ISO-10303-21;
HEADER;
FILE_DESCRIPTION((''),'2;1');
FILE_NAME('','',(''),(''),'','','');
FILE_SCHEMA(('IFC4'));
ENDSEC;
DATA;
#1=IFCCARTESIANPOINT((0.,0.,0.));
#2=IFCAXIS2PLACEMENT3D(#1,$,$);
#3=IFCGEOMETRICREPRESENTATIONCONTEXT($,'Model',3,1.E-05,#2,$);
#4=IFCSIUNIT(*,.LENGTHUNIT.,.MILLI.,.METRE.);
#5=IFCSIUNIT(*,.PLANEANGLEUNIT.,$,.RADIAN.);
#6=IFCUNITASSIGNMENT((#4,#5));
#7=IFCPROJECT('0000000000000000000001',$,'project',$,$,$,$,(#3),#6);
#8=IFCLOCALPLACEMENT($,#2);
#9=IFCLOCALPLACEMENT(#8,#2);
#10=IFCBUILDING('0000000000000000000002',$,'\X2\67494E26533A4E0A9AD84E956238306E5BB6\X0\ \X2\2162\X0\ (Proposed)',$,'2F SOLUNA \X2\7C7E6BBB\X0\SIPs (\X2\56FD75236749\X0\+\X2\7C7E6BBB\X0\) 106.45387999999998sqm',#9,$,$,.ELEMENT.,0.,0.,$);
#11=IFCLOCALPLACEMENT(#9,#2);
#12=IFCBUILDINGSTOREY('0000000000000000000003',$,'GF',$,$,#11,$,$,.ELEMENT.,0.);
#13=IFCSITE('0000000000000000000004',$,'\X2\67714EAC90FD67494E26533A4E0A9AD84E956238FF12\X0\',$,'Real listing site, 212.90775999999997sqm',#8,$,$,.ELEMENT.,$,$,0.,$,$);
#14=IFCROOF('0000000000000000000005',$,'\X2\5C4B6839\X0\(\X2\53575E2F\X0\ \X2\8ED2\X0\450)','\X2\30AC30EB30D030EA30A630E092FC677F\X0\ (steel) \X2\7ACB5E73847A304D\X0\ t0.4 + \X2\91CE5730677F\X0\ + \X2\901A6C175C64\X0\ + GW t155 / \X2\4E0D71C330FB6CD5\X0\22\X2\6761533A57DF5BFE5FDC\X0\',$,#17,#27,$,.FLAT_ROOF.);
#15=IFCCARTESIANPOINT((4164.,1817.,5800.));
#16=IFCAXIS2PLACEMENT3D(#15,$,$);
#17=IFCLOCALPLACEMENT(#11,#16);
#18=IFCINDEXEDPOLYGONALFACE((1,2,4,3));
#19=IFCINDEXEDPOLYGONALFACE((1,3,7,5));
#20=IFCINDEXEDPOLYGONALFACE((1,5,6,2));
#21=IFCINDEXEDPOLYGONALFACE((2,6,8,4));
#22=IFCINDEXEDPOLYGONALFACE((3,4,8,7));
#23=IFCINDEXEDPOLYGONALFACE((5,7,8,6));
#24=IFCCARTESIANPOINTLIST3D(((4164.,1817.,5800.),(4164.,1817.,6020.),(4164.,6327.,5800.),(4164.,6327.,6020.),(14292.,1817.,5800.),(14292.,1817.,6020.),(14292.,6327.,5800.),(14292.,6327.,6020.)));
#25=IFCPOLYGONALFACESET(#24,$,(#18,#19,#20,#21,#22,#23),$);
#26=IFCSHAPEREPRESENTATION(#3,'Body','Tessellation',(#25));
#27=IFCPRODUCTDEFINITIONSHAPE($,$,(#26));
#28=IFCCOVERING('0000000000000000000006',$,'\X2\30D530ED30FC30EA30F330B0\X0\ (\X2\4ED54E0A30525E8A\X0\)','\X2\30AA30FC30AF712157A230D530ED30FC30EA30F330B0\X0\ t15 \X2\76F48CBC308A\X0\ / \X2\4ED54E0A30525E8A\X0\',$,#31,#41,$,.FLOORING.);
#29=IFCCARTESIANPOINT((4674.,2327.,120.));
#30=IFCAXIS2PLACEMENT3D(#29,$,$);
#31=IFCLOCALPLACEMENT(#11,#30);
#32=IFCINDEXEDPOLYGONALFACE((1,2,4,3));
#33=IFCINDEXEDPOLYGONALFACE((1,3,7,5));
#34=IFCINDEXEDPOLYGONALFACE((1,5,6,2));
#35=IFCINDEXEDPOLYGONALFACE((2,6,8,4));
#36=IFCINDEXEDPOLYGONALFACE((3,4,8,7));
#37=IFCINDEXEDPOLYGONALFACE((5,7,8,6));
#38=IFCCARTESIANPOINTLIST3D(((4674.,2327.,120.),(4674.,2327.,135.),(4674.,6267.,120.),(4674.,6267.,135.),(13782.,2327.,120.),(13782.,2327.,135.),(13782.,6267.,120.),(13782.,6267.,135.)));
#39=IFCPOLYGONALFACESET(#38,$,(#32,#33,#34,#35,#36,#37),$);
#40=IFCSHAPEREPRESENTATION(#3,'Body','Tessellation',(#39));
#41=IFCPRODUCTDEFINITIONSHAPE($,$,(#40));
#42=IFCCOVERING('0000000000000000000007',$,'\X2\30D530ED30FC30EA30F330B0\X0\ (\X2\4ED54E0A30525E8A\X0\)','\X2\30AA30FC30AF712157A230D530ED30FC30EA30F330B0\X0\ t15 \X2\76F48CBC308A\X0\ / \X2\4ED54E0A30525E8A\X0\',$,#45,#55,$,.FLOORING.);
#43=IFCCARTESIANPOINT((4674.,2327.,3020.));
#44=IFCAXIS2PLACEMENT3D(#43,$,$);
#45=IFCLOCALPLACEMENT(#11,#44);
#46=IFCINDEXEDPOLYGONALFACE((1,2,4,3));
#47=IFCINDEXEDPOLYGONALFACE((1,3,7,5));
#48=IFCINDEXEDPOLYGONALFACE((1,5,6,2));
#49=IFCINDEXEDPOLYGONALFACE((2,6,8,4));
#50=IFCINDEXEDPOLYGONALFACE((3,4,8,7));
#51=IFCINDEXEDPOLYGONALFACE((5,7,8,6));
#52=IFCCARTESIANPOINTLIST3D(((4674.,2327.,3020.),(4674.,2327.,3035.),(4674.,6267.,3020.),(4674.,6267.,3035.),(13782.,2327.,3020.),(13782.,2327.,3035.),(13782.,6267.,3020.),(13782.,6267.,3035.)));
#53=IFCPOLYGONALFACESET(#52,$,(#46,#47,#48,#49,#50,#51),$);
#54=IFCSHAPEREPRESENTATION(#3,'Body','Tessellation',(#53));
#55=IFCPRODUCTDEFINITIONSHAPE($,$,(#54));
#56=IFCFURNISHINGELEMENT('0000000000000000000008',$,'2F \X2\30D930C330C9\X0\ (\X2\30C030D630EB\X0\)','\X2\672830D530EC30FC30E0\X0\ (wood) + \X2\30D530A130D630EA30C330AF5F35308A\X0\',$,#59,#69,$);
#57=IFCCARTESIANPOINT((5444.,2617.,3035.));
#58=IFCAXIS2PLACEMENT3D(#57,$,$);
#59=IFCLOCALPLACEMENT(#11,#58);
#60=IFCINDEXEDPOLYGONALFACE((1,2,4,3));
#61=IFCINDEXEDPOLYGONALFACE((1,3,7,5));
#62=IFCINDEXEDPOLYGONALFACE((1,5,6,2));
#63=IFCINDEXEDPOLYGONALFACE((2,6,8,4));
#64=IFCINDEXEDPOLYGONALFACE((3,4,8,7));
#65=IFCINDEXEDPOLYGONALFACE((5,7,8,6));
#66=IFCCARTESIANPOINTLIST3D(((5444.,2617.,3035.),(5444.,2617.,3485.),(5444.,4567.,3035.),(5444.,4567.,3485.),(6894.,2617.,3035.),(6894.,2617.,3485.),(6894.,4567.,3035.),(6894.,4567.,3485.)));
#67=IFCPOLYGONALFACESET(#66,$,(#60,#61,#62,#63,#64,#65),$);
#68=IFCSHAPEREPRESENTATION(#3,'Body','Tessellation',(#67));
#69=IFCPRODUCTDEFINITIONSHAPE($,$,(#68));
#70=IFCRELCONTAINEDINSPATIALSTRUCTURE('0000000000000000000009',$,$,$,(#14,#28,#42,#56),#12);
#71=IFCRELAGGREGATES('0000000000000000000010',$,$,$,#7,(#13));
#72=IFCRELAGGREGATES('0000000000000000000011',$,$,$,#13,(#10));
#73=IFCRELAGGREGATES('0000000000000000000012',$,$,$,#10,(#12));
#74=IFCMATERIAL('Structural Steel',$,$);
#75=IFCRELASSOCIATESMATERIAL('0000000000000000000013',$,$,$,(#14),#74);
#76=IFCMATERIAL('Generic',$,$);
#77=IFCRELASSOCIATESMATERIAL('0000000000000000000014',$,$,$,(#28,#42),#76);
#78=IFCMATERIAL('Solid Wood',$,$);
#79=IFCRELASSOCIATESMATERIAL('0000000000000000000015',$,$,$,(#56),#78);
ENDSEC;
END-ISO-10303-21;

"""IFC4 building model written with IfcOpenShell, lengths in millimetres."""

from ifc_helpers import new_model, si_unit, frame, frame_2d, origin, place, context, project, spatial, rectangle, extrude, material, element, save


model = new_model("IFC4")

# Units and contexts
model_context = context("Model", 3, precision=1e-05, world=origin())
ifc_project = project(units=[si_unit("LENGTHUNIT", "METRE", prefix="MILLI"), si_unit("PLANEANGLEUNIT", "RADIAN")], contexts=[model_context])

# Site, building, storey
site_placement = place(None, origin())
site = spatial("IfcSite", under=ifc_project, at=site_placement, Name="東京都杉並区上高井戸２", ObjectType="Real listing site, 212.90775999999997sqm", CompositionType="ELEMENT", RefElevation=0.0)
building_placement = place(site_placement, origin())
building = spatial("IfcBuilding", under=site, at=building_placement, Name="杉並区上高井戸の家 Ⅲ (Proposed)", ObjectType="2F SOLUNA 籾殻SIPs (国産杉+籾殻) 106.45387999999998sqm", CompositionType="ELEMENT", ElevationOfRefHeight=0.0, ElevationOfTerrain=0.0)
storey_placement = place(building_placement, origin())
storey = spatial("IfcBuildingStorey", under=building, at=storey_placement, Name="GF", CompositionType="ELEMENT", Elevation=0.0)

# Shared definitions
ifc_material_1 = material(Name="Solid Wood")

# Roof
ifc_material_2 = material(Name="Structural Steel")
for number, where, name in (
    (1, (4164.0, 1817.0, 5800.0), "屋根(南帯 軒450)"),
):
    element("IfcRoof", number, at=place(storey_placement, frame(where)), inside=storey, material=ifc_material_2, Name=name, Description="ガルバリウム鋼板 (steel) 立平葺き t0.4 + 野地板 + 通気層 + GW t155 / 不燃・法22条区域対応", PredefinedType="FLAT_ROOF", context=model_context, shape_type="SweptSolid", body=[
        extrude(rectangle(XDim=10128.0, YDim=4510.0, at=frame_2d((5064.0, 2255.0))), frame((4164.0, 1817.0, 5800.0)), (0.0, 0.0, 1.0), 220.0),
    ])

# Coverings
ifc_material_3 = material(Name="Generic")
covering_1_placement = place(storey_placement, frame((4674.0, 2327.0, 120.0)))
element("IfcCovering", 2, at=covering_1_placement, inside=storey, material=ifc_material_3, Name="フローリング (仕上げ床)", Description="オーク無垢フローリング t15 直貼り / 仕上げ床", PredefinedType="FLOORING", context=model_context, shape_type="SweptSolid", body=[
    extrude(rectangle(XDim=9108.0, YDim=3940.0, at=frame_2d((4554.0, 1970.0))), frame((4674.0, 2327.0, 120.0)), (0.0, 0.0, 1.0), 15.0),
])
covering_2_placement = place(storey_placement, frame((4674.0, 2327.0, 3020.0)))
element("IfcCovering", 3, at=covering_2_placement, inside=storey, material=ifc_material_3, Name="フローリング (仕上げ床)", Description="オーク無垢フローリング t15 直貼り / 仕上げ床", PredefinedType="FLOORING", context=model_context, shape_type="SweptSolid", body=[
    extrude(rectangle(XDim=9108.0, YDim=3940.0, at=frame_2d((4554.0, 1970.0))), frame((4674.0, 2327.0, 3020.0)), (0.0, 0.0, 1.0), 15.0),
])

# Furnishing element
furnishing_placement = place(storey_placement, frame((5444.0, 2617.0, 3035.0)))
element("IfcFurnishingElement", 4, at=furnishing_placement, inside=storey, material=ifc_material_1, Name="2F ベッド (ダブル)", Description="木フレーム (wood) + ファブリック張り", context=model_context, shape_type="SweptSolid", body=[
    extrude(rectangle(XDim=1450.0, YDim=1950.0, at=frame_2d((725.0, 975.0))), frame((5444.0, 2617.0, 3035.0)), (0.0, 0.0, 1.0), 450.0),
])

save(model, "model.ifc")
